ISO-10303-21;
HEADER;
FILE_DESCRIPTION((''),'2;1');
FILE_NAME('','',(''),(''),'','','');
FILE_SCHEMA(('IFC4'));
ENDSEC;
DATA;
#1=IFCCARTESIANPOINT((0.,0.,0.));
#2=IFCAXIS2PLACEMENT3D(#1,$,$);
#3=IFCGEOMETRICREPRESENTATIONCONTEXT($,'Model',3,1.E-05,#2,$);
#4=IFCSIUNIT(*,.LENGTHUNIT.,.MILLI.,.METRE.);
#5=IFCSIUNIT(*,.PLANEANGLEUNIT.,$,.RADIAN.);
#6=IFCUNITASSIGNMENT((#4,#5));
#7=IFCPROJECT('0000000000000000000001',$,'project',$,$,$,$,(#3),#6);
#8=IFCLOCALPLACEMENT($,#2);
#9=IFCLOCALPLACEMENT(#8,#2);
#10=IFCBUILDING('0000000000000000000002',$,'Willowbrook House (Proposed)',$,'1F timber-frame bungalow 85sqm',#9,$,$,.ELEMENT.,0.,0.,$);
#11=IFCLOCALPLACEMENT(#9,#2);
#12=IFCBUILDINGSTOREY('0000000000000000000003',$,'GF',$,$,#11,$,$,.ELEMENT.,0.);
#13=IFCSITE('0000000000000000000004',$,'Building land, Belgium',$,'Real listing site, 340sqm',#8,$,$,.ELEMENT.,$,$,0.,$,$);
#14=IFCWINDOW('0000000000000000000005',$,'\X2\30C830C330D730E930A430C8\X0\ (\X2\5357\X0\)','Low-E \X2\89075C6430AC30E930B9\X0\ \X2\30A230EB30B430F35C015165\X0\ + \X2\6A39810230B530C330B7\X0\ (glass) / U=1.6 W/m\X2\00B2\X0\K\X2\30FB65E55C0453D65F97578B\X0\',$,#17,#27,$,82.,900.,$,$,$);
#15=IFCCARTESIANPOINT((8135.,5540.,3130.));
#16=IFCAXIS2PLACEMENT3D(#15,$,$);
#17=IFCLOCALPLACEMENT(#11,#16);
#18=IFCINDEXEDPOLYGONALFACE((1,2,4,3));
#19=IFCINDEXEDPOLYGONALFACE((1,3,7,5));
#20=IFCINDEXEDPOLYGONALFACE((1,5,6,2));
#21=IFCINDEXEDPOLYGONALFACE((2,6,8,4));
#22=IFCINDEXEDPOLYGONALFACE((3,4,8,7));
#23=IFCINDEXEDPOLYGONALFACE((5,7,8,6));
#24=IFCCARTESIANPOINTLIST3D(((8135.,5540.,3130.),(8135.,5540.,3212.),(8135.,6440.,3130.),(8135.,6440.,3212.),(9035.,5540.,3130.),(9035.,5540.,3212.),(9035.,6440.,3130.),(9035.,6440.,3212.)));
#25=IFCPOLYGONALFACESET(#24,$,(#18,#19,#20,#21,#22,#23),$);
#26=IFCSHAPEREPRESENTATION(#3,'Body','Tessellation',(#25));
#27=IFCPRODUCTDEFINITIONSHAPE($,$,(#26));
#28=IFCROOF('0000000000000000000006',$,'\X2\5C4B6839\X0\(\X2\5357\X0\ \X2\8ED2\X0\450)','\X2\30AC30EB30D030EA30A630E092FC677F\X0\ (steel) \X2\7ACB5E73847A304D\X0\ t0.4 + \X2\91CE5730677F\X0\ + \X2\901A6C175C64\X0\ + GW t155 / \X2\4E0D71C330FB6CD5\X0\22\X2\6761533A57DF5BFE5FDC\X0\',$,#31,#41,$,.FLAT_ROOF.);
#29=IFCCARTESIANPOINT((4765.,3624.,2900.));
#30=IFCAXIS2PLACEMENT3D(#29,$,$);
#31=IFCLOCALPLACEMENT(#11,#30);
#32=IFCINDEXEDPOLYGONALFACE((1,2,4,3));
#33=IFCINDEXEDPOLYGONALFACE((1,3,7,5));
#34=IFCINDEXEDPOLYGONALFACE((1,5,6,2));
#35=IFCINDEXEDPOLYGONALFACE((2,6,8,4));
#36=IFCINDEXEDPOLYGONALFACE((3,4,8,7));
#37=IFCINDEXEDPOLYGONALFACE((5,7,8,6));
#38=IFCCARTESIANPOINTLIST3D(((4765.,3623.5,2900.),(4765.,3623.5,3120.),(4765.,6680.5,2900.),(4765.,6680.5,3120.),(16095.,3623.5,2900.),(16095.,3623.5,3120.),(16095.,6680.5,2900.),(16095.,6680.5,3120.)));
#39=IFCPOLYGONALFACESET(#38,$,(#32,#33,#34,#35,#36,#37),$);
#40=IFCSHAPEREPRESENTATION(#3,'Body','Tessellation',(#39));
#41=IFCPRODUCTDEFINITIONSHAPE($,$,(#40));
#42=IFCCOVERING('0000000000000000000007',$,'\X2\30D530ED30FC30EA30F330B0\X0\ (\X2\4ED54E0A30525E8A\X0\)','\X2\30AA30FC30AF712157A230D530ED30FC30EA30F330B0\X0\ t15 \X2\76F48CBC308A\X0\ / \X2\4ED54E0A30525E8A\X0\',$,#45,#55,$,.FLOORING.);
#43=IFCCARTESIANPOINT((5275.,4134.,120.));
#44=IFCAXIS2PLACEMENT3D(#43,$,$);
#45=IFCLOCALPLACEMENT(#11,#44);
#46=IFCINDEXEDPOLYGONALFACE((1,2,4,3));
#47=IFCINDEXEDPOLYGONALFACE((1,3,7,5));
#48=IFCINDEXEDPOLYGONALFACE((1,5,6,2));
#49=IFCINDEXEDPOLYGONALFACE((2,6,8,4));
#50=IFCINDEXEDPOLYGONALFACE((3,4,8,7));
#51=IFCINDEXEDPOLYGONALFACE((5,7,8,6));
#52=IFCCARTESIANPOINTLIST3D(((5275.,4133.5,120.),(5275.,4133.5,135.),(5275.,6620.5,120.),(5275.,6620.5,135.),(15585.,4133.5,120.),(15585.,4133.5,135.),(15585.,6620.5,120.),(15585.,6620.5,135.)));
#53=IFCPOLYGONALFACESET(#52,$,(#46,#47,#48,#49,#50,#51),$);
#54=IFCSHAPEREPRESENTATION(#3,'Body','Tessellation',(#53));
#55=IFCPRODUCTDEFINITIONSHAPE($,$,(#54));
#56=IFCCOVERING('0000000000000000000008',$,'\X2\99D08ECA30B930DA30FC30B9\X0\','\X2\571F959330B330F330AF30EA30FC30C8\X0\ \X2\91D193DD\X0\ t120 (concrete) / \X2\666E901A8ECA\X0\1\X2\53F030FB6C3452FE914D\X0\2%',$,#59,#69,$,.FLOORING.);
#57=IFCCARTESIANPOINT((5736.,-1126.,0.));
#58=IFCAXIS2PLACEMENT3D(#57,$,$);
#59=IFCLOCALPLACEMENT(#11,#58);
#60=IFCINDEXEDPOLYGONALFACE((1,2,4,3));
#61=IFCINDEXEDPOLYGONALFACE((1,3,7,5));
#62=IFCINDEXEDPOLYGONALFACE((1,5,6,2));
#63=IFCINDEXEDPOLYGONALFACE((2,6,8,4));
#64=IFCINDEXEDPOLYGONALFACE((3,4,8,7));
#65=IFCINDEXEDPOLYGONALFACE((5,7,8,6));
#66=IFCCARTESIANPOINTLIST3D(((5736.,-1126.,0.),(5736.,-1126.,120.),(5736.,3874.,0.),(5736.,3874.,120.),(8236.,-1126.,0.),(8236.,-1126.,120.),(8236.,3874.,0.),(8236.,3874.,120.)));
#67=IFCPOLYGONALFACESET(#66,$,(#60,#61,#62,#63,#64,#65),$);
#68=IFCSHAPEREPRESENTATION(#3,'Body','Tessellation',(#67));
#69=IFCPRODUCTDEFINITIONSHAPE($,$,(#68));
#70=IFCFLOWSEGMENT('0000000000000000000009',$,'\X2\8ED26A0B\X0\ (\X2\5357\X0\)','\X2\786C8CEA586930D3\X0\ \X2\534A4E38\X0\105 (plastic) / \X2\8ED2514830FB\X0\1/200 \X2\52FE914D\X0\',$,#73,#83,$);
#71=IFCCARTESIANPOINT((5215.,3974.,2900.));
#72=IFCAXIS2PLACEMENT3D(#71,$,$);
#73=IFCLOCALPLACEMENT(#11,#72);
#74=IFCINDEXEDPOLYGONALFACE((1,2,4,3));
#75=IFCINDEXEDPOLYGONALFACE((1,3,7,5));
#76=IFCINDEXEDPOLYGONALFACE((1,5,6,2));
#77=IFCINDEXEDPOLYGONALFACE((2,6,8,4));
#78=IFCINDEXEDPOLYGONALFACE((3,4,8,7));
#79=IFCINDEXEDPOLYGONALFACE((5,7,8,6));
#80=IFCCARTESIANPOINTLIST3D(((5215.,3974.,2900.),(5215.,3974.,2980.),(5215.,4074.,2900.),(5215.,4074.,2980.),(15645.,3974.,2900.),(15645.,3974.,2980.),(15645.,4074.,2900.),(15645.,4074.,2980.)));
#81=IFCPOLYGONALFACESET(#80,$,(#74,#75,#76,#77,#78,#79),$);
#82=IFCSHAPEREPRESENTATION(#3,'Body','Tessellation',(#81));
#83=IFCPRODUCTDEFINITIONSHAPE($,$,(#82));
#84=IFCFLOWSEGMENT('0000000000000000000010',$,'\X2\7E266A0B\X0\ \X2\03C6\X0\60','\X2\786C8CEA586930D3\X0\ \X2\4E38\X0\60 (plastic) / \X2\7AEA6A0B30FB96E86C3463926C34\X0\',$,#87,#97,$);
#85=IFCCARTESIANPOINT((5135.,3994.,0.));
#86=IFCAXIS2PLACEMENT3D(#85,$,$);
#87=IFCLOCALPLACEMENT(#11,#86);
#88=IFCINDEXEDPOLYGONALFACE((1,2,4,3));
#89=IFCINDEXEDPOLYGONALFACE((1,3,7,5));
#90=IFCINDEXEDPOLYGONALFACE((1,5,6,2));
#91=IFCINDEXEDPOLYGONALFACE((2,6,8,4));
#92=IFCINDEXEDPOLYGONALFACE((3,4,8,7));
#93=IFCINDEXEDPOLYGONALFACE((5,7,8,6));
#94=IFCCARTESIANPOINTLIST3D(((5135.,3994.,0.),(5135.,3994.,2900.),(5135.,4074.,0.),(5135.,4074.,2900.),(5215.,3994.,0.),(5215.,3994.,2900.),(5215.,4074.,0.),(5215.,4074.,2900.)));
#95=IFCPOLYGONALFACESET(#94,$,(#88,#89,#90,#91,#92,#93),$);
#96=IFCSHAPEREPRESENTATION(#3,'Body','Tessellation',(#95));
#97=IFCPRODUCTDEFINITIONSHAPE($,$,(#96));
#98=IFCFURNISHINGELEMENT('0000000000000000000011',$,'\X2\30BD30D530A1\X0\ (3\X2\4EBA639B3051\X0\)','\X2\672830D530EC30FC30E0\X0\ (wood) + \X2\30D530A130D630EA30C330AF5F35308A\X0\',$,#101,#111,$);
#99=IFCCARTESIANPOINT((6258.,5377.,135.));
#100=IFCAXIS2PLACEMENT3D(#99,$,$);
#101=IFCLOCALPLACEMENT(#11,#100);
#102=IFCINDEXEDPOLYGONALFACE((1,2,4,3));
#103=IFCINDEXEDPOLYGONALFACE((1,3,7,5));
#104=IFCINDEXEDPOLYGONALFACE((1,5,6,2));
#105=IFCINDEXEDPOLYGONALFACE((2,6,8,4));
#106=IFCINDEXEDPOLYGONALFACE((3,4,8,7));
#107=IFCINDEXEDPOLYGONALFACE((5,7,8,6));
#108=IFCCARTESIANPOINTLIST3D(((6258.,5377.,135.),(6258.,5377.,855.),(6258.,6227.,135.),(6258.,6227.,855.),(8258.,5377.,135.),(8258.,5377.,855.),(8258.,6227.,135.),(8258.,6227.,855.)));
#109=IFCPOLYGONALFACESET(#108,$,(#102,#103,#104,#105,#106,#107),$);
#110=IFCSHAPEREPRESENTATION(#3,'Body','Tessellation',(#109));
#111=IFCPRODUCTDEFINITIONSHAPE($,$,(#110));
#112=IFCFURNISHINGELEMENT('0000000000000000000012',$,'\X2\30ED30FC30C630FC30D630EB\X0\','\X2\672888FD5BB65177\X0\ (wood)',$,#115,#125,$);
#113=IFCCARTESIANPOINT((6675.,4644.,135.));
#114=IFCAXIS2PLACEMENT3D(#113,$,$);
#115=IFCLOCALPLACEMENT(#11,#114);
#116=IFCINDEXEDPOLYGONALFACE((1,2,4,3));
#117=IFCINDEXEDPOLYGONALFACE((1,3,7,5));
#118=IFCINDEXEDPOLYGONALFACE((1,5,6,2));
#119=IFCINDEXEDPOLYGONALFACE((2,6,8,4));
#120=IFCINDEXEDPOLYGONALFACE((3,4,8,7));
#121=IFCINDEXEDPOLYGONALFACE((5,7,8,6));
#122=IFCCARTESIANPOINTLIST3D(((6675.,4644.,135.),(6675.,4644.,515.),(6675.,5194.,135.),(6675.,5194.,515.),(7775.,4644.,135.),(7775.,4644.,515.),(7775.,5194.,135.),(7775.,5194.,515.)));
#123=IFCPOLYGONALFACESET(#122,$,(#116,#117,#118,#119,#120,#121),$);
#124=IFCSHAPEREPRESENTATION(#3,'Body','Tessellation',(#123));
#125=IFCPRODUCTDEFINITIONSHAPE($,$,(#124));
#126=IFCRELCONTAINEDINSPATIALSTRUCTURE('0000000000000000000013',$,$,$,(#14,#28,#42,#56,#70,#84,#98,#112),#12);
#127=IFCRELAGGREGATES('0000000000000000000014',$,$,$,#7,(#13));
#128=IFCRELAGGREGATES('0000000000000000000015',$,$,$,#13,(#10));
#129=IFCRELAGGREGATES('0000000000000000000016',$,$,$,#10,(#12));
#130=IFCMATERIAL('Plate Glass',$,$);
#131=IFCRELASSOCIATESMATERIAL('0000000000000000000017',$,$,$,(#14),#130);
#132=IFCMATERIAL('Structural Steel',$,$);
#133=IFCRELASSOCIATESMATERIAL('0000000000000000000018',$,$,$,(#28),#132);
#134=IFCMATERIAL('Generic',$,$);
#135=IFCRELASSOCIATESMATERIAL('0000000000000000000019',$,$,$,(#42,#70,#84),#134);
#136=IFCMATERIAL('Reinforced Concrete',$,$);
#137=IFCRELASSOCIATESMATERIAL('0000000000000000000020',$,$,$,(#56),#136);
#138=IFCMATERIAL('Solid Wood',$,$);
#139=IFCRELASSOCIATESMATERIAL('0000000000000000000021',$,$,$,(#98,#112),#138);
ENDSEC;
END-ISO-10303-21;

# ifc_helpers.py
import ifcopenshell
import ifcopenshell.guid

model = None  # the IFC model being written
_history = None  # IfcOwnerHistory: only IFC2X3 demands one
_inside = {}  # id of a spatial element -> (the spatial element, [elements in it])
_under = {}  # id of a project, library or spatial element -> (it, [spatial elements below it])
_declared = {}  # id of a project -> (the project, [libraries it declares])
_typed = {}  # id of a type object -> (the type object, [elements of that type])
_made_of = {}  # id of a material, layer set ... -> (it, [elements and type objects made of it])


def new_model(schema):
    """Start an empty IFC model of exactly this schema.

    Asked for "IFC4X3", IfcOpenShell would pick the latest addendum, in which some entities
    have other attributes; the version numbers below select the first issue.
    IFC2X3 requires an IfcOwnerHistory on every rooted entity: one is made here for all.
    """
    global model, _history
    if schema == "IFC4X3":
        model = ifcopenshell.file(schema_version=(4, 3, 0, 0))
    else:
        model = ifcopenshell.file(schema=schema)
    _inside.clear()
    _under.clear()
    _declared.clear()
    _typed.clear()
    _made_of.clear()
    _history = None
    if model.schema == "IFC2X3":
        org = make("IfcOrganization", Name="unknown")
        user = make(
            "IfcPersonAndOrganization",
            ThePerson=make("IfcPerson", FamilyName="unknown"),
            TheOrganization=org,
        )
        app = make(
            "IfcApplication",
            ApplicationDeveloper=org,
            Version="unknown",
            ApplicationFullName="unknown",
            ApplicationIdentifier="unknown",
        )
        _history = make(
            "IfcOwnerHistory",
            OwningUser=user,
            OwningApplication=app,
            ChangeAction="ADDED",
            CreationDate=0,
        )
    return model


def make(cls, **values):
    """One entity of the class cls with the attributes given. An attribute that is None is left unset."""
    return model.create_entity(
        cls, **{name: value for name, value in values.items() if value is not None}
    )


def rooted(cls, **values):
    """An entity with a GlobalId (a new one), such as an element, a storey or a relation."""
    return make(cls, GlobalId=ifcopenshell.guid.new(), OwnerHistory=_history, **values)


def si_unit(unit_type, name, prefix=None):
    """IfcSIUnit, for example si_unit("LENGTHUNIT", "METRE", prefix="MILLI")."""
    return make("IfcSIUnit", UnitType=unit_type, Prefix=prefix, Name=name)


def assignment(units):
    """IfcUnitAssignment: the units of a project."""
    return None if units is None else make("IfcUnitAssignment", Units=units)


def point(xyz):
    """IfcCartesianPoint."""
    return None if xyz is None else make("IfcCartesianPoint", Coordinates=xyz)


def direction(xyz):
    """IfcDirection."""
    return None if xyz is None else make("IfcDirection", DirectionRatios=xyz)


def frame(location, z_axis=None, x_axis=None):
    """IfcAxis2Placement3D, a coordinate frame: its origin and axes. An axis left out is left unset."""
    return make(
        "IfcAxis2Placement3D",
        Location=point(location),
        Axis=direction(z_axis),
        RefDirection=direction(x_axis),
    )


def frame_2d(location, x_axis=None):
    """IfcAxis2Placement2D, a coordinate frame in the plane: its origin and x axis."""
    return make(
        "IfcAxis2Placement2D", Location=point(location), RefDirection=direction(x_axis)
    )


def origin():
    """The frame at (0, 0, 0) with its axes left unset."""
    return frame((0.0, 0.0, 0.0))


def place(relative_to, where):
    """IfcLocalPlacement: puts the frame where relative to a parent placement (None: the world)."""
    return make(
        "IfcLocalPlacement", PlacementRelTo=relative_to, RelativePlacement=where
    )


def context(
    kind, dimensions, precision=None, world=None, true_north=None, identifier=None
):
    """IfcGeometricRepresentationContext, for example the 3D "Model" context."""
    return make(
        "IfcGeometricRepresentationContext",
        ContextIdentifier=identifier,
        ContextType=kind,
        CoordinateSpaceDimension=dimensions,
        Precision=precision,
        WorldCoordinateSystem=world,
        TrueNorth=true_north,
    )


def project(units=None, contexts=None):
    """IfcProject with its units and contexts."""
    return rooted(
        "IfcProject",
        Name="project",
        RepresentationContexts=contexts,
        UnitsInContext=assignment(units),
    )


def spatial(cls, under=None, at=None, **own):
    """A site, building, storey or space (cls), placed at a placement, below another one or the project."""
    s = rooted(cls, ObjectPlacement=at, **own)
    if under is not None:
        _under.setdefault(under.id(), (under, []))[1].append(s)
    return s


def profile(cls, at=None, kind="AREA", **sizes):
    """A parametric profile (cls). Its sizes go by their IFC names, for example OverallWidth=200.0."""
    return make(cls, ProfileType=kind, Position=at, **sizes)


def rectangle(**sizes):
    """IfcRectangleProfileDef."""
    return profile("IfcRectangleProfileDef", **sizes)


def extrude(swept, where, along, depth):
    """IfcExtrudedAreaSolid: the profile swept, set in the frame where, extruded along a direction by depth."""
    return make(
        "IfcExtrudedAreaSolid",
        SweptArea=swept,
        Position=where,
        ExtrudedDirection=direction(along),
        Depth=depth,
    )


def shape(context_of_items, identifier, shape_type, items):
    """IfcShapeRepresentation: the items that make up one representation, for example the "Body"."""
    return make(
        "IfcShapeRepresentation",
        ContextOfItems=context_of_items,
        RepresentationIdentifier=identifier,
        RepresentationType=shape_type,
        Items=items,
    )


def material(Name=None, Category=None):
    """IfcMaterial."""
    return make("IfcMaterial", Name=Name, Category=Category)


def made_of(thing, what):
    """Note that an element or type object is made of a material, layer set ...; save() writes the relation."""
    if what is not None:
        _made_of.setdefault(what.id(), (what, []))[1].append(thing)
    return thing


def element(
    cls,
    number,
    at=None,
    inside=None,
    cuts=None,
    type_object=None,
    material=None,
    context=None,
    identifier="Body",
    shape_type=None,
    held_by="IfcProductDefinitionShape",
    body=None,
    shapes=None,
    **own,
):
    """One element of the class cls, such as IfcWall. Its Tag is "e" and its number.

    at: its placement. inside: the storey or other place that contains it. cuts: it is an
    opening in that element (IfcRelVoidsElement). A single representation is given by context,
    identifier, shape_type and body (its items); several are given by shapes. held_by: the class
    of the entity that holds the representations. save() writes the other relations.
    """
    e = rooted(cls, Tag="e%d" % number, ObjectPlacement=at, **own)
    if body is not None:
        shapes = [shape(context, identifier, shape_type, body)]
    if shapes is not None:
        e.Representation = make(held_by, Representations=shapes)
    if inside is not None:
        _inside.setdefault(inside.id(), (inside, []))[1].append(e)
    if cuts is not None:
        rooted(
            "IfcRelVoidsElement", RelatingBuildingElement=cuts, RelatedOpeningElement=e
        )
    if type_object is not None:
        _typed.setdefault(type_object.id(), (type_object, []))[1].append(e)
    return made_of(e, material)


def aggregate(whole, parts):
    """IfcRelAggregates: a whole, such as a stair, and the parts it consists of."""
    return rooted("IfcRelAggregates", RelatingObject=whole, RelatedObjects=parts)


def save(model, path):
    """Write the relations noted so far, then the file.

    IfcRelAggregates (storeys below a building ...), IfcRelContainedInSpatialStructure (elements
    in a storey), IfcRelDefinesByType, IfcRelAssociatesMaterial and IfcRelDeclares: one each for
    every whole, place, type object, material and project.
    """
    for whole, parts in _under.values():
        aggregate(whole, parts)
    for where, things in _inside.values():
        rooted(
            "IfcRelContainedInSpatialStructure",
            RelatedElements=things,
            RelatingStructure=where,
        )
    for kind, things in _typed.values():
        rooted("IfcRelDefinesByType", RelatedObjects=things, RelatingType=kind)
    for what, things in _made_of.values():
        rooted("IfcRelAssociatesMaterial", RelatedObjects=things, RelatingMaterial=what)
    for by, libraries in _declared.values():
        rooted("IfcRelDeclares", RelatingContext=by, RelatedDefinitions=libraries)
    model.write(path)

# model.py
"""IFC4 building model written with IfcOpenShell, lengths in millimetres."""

from ifc_helpers import new_model, si_unit, frame, frame_2d, origin, place, context, project, spatial, rectangle, extrude, material, element, save


model = new_model("IFC4")

# Units and contexts
model_context = context("Model", 3, precision=1e-05, world=origin())
ifc_project = project(units=[si_unit("LENGTHUNIT", "METRE", prefix="MILLI"), si_unit("PLANEANGLEUNIT", "RADIAN")], contexts=[model_context])

# Site, building, storey
site_placement = place(None, origin())
site = spatial("IfcSite", under=ifc_project, at=site_placement, Name="Building land, Belgium", ObjectType="Real listing site, 340sqm", CompositionType="ELEMENT", RefElevation=0.0)
building_placement = place(site_placement, origin())
building = spatial("IfcBuilding", under=site, at=building_placement, Name="Willowbrook House (Proposed)", ObjectType="1F timber-frame bungalow 85sqm", CompositionType="ELEMENT", ElevationOfRefHeight=0.0, ElevationOfTerrain=0.0)
storey_placement = place(building_placement, origin())
storey = spatial("IfcBuildingStorey", under=building, at=storey_placement, Name="GF", CompositionType="ELEMENT", Elevation=0.0)

# Shared definitions
ifc_material_1 = material(Name="Solid Wood")

# Shared definitions
ifc_material_2 = material(Name="Reinforced Concrete")

# Shared definitions
ifc_material_3 = material(Name="Plate Glass")

# Window
window_1_placement = place(storey_placement, frame((8135.0, 5540.0, 3130.0)))
element("IfcWindow", 1, at=window_1_placement, inside=storey, material=ifc_material_3, Name="トップライト (南)", Description="Low-E 複層ガラス アルゴン封入 + 樹脂サッシ (glass) / U=1.6 W/m²K・日射取得型", OverallHeight=82.0, OverallWidth=900.0, context=model_context, shape_type="SweptSolid", body=[
    extrude(rectangle(XDim=900.0, YDim=900.0, at=frame_2d((450.0, 450.0))), frame((8135.0, 5540.0, 3130.0)), (0.0, 0.0, 1.0), 82.0),
])

# Roof
ifc_material_4 = material(Name="Structural Steel")
roof_1_placement = place(storey_placement, frame((4765.0, 3624.0, 2900.0)))
element("IfcRoof", 2, at=roof_1_placement, inside=storey, material=ifc_material_4, Name="屋根(南 軒450)", Description="ガルバリウム鋼板 (steel) 立平葺き t0.4 + 野地板 + 通気層 + GW t155 / 不燃・法22条区域対応", PredefinedType="FLAT_ROOF", context=model_context, shape_type="SweptSolid", body=[
    extrude(rectangle(XDim=11330.0, YDim=3057.0, at=frame_2d((5665.0, 1528.0))), frame((4765.0, 3624.0, 2900.0)), (0.0, 0.0, 1.0), 220.0),
])

# Coverings
ifc_material_5 = material(Name="Generic")
covering_1_placement = place(storey_placement, frame((5275.0, 4134.0, 120.0)))
element("IfcCovering", 3, at=covering_1_placement, inside=storey, material=ifc_material_5, Name="フローリング (仕上げ床)", Description="オーク無垢フローリング t15 直貼り / 仕上げ床", PredefinedType="FLOORING", context=model_context, shape_type="SweptSolid", body=[
    extrude(rectangle(XDim=10310.0, YDim=2487.0, at=frame_2d((5155.0, 1243.0))), frame((5275.0, 4134.0, 120.0)), (0.0, 0.0, 1.0), 15.0),
])
covering_2_placement = place(storey_placement, frame((5736.0, -1126.0, 0.0)))
element("IfcCovering", 4, at=covering_2_placement, inside=storey, material=ifc_material_2, Name="駐車スペース", Description="土間コンクリート 金鏝 t120 (concrete) / 普通車1台・水勾配2%", PredefinedType="FLOORING", context=model_context, shape_type="SweptSolid", body=[
    extrude(rectangle(XDim=2500.0, YDim=5000.0, at=frame_2d((1250.0, 2500.0))), frame((5736.0, -1126.0, 0.0)), (0.0, 0.0, 1.0), 120.0),
])

# Flow segments
flow_segment_1_placement = place(storey_placement, frame((5215.0, 3974.0, 2900.0)))
element("IfcFlowSegment", 5, at=flow_segment_1_placement, inside=storey, material=ifc_material_5, Name="軒樋 (南)", Description="硬質塩ビ 半丸105 (plastic) / 軒先・1/200 勾配", context=model_context, shape_type="SweptSolid", body=[
    extrude(rectangle(XDim=10430.0, YDim=100.0, at=frame_2d((5215.0, 50.0))), frame((5215.0, 3974.0, 2900.0)), (0.0, 0.0, 1.0), 80.0),
])
flow_segment_2_placement = place(storey_placement, frame((5135.0, 3994.0, 0.0)))
element("IfcFlowSegment", 6, at=flow_segment_2_placement, inside=storey, material=ifc_material_5, Name="縦樋 φ60", Description="硬質塩ビ 丸60 (plastic) / 竪樋・雨水排水", context=model_context, shape_type="SweptSolid", body=[
    extrude(rectangle(XDim=80.0, YDim=80.0, at=frame_2d((40.0, 40.0))), frame((5135.0, 3994.0, 0.0)), (0.0, 0.0, 1.0), 2900.0),
])

# Furnishing elements
furnishing_1_placement = place(storey_placement, frame((6258.0, 5377.0, 135.0)))
element("IfcFurnishingElement", 7, at=furnishing_1_placement, inside=storey, material=ifc_material_1, Name="ソファ (3人掛け)", Description="木フレーム (wood) + ファブリック張り", context=model_context, shape_type="SweptSolid", body=[
    extrude(rectangle(XDim=2000.0, YDim=850.0, at=frame_2d((1000.0, 425.0))), frame((6258.0, 5377.0, 135.0)), (0.0, 0.0, 1.0), 720.0),
])
furnishing_2_placement = place(storey_placement, frame((6675.0, 4644.0, 135.0)))
element("IfcFurnishingElement", 8, at=furnishing_2_placement, inside=storey, material=ifc_material_1, Name="ローテーブル", Description="木製家具 (wood)", context=model_context, shape_type="SweptSolid", body=[
    extrude(rectangle(XDim=1100.0, YDim=550.0, at=frame_2d((550.0, 275.0))), frame((6675.0, 4644.0, 135.0)), (0.0, 0.0, 1.0), 380.0),
])

save(model, "model.ifc")
